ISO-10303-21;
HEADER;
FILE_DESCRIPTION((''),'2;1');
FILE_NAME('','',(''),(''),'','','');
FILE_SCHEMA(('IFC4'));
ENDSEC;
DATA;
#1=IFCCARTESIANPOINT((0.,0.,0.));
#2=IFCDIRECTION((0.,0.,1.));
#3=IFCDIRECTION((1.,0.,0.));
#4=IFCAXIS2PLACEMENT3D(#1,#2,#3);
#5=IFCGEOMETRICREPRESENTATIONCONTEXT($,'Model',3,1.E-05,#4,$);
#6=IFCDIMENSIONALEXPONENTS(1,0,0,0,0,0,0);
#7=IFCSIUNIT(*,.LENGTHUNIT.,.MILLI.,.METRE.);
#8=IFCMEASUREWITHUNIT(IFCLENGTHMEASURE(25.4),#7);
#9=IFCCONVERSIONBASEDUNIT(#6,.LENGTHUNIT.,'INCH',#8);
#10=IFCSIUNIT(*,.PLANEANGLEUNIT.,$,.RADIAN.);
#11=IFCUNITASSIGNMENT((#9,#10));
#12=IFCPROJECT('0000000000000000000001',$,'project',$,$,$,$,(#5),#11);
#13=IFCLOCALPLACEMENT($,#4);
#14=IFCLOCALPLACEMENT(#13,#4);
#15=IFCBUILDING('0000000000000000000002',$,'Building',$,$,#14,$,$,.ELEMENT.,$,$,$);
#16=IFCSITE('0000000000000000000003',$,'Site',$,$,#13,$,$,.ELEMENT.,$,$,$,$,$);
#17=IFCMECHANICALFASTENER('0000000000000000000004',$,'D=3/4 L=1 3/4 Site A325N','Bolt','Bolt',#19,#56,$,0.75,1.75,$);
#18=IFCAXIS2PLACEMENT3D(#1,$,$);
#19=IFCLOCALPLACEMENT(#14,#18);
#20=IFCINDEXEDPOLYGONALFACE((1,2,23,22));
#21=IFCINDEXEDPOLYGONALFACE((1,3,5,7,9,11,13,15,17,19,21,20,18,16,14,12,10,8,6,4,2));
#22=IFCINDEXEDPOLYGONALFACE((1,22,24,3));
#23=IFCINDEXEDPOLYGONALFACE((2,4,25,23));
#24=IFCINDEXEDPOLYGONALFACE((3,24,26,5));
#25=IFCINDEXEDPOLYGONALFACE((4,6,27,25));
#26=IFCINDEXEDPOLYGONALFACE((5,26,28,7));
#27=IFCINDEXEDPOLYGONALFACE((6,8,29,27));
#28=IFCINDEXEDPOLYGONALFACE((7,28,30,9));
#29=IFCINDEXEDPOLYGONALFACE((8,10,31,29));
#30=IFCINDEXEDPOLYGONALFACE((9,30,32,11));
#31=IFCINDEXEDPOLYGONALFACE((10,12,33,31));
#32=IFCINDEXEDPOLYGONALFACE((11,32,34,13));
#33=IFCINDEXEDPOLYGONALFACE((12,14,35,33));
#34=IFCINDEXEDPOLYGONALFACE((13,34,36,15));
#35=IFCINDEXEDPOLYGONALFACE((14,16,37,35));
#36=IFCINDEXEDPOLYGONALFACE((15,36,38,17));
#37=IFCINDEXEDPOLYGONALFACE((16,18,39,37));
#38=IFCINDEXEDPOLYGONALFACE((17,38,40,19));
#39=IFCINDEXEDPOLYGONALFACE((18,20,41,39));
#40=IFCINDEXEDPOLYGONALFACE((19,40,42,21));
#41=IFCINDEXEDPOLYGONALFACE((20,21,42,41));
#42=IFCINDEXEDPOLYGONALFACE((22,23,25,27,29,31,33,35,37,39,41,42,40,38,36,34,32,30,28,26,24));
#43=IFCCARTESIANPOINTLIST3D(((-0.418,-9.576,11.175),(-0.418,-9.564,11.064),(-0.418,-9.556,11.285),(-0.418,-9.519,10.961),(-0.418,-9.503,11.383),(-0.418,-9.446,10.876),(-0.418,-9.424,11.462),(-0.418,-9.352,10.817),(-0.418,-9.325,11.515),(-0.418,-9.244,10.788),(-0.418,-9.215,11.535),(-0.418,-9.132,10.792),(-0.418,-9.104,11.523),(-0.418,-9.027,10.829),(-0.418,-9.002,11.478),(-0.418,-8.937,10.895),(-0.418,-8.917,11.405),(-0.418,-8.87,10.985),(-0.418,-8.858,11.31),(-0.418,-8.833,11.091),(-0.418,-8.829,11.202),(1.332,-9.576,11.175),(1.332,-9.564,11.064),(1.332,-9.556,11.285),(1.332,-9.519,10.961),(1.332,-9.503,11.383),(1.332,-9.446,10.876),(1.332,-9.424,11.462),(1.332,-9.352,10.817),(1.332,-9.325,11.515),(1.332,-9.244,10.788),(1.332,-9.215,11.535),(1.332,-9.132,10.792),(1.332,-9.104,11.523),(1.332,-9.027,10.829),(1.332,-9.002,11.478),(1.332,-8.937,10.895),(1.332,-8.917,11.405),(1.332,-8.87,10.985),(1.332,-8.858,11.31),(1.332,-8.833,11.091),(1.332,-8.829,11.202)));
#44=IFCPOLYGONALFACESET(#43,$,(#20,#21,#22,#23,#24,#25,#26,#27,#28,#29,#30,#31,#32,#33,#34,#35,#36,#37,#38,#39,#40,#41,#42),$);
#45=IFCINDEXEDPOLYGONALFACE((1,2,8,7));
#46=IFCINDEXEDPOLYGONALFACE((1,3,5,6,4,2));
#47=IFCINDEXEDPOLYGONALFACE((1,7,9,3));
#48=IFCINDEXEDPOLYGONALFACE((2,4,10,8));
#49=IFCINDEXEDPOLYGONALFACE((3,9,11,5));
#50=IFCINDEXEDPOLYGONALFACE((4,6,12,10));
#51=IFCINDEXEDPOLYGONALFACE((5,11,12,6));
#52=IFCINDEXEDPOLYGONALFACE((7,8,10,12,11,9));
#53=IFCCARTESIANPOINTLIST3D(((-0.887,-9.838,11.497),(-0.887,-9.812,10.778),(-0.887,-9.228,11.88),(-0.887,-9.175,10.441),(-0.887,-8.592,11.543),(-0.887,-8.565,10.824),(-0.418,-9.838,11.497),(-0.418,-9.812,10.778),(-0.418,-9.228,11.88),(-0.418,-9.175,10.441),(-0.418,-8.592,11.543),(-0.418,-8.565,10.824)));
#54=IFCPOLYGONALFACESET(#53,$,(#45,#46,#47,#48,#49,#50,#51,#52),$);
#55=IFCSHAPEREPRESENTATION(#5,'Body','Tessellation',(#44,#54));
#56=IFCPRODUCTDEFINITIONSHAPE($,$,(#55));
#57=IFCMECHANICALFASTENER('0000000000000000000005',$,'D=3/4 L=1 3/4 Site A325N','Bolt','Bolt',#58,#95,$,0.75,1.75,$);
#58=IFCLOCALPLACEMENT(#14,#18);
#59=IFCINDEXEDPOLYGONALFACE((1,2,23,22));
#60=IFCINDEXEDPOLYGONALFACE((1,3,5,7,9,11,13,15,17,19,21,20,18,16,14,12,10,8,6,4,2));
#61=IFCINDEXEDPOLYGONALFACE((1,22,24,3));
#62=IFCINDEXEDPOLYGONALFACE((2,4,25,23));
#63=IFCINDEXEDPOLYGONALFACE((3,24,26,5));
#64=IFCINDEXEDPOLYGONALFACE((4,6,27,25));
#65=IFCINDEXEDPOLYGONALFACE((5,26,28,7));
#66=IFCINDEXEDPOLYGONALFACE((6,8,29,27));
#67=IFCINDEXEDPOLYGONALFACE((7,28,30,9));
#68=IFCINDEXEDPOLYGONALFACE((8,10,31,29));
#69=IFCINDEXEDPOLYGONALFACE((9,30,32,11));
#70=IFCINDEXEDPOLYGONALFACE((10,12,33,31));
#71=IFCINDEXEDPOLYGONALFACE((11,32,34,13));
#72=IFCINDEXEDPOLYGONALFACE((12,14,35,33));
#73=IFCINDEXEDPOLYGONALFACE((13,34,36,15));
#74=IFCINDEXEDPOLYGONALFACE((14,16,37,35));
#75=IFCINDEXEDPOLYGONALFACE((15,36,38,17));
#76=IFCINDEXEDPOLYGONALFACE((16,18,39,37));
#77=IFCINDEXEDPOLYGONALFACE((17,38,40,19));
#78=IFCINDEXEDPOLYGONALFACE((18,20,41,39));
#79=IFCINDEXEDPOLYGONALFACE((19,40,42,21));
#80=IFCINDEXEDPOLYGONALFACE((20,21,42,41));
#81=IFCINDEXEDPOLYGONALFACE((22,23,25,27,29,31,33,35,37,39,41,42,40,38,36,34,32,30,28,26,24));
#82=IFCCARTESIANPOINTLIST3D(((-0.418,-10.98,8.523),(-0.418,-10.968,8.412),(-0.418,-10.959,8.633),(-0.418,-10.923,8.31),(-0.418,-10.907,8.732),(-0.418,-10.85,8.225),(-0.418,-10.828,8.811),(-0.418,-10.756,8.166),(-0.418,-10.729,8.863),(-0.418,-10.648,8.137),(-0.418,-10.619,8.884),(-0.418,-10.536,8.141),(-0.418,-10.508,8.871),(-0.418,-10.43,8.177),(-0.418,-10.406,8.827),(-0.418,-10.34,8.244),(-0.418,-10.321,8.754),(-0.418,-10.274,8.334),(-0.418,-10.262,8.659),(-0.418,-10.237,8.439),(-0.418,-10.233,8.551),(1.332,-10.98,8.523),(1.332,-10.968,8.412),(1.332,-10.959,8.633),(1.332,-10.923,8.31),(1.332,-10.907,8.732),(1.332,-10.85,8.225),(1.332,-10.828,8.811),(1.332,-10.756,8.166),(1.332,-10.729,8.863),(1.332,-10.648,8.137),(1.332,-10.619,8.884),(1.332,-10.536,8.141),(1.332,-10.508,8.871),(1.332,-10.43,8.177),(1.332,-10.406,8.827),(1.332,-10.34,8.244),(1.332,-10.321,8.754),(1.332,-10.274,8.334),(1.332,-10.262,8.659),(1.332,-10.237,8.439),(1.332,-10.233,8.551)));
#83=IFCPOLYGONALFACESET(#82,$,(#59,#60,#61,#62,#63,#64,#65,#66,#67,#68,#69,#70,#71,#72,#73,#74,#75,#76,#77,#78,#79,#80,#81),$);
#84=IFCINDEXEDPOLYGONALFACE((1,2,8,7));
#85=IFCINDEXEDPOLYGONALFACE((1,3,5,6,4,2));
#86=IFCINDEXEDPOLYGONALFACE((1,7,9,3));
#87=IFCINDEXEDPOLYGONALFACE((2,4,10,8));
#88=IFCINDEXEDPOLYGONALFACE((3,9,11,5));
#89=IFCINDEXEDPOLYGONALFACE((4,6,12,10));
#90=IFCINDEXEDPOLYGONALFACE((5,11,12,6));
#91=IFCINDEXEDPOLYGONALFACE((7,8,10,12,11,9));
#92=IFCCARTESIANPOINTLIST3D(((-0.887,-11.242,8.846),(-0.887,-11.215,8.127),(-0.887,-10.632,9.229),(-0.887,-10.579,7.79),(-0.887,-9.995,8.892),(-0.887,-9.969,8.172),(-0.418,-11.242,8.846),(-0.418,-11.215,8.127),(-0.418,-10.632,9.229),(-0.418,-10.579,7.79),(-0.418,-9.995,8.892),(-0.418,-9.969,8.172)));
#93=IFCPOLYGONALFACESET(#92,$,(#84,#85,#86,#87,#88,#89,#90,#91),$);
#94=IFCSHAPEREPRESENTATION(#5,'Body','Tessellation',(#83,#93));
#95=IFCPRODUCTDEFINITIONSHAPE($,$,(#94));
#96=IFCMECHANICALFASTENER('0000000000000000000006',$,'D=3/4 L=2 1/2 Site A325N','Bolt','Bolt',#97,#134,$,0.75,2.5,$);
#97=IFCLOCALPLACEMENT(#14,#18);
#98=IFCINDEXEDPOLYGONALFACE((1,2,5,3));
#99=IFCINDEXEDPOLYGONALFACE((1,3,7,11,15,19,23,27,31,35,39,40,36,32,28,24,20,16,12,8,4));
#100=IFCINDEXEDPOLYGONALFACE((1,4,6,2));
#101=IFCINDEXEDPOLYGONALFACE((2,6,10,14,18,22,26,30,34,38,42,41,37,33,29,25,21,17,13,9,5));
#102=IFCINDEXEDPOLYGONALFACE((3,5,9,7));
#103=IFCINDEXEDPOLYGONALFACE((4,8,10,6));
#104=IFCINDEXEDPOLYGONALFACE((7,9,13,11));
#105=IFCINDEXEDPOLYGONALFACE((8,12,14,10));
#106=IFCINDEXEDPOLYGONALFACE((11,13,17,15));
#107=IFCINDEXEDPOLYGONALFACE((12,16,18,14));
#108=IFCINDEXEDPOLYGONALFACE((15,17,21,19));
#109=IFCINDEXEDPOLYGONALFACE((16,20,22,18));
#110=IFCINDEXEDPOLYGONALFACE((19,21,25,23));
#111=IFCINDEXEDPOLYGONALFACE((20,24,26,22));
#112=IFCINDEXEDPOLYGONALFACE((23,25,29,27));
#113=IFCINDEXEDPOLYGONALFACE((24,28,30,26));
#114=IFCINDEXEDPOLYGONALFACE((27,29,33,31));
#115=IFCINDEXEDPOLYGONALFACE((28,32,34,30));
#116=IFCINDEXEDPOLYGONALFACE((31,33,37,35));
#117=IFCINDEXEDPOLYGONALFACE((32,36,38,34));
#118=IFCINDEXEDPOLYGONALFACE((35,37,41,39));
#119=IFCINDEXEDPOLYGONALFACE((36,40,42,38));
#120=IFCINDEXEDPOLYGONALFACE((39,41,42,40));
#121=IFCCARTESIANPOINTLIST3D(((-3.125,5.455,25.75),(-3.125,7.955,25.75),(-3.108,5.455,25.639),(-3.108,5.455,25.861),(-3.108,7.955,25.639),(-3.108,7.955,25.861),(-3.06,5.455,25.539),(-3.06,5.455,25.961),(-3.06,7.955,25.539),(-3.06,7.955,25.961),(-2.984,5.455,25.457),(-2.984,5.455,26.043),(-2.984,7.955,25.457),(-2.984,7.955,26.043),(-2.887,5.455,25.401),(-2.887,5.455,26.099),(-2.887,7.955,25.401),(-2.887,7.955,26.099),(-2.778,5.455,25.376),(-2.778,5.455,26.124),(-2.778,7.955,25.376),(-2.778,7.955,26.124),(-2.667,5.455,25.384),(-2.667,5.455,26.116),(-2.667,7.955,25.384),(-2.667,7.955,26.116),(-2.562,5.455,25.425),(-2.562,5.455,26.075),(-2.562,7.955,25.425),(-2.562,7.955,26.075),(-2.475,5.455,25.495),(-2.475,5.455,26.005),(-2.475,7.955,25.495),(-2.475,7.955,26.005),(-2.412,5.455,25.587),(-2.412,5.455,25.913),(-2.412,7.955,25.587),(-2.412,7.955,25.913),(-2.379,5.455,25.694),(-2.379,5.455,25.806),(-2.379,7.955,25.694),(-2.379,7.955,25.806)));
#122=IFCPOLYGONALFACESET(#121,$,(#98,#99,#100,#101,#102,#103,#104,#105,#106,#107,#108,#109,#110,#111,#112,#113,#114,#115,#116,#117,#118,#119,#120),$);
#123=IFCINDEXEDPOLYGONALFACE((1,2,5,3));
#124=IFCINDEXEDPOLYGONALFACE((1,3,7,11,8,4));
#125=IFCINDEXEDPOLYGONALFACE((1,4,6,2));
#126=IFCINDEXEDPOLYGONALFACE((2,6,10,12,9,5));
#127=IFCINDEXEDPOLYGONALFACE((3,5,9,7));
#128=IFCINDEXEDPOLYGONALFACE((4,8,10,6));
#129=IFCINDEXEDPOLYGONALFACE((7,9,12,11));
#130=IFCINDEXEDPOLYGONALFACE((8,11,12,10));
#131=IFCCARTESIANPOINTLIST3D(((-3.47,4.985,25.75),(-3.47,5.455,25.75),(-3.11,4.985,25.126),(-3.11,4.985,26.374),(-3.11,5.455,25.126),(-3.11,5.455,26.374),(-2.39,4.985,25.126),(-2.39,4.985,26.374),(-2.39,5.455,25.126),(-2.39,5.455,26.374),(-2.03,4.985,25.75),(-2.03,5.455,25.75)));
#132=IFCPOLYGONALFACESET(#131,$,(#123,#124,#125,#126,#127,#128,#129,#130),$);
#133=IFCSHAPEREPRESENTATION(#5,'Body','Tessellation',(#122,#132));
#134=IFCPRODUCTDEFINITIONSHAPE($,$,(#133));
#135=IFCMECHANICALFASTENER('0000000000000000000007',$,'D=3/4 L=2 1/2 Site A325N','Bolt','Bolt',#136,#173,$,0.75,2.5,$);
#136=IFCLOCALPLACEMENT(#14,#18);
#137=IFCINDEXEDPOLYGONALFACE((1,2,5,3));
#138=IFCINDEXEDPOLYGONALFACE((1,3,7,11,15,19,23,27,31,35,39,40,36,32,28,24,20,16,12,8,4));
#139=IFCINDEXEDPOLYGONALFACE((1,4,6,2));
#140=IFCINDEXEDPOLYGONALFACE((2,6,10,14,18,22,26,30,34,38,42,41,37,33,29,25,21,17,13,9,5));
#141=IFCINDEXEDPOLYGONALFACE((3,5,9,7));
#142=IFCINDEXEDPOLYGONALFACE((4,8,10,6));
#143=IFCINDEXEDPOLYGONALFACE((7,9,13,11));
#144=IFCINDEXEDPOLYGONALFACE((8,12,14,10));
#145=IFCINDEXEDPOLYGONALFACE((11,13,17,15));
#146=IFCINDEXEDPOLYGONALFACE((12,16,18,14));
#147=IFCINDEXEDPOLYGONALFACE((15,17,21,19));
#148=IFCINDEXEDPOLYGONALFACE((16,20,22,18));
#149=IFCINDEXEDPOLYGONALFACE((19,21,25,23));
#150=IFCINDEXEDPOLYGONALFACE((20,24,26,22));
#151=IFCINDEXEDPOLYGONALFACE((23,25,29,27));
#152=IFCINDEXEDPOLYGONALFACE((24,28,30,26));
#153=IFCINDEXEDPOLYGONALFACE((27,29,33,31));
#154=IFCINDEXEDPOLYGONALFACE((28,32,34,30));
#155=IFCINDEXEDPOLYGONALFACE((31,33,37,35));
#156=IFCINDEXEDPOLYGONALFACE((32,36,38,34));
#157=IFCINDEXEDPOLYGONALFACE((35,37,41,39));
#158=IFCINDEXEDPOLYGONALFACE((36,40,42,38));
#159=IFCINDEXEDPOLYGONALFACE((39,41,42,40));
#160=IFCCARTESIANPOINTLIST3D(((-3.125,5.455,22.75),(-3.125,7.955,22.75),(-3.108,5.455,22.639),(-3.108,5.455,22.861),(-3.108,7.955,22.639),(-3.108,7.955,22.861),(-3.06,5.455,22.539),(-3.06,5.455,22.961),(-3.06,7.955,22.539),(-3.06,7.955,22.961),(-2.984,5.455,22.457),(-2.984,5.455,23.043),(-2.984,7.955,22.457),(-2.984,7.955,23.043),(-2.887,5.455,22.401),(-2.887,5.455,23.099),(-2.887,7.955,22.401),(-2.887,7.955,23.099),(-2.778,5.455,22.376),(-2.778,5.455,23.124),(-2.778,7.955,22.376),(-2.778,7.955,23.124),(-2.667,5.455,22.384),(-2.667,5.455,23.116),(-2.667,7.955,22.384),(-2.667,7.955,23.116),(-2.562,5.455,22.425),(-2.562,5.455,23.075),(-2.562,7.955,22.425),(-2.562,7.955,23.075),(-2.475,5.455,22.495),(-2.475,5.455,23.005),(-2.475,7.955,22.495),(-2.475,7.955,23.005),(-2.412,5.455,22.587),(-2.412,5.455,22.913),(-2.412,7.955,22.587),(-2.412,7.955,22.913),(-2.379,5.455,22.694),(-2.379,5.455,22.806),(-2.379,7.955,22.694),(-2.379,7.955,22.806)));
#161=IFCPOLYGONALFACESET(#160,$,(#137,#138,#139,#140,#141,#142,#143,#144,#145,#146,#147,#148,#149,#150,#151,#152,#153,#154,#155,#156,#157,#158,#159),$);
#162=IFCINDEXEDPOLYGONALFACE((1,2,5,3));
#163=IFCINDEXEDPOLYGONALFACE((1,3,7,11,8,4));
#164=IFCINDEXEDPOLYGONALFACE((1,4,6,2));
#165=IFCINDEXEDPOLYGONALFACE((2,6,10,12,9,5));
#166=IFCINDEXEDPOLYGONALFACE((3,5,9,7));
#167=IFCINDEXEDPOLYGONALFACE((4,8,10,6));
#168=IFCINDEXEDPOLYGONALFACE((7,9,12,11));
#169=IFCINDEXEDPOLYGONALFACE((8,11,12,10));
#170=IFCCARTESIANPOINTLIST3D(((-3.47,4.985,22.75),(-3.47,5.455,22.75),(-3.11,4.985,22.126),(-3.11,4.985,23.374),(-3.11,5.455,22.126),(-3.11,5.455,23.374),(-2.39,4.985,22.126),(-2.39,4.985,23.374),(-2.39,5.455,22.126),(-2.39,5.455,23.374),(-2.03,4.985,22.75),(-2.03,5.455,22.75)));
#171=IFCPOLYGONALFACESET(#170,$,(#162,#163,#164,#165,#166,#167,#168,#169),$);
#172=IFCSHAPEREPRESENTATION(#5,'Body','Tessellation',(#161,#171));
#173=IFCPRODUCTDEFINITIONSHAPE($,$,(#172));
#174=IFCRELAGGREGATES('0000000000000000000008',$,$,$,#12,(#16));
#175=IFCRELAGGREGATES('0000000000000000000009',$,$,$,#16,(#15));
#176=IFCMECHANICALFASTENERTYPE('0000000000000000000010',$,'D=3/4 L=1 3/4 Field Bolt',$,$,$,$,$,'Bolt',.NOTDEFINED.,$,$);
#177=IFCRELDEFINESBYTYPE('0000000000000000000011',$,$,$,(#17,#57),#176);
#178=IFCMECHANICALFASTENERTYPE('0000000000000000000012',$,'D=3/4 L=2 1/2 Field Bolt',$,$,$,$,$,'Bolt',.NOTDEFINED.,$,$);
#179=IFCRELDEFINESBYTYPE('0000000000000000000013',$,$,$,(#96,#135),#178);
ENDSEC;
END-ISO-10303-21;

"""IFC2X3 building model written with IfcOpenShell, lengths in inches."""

from ifc_helpers import new_model, entity, si_unit, converted_unit, frame, origin_with_axes, origin_2d_with_axis, place, context, project, spatial, polyline, circle, outline, extrude, source, transform, mapped, type_object, type_shapes, element, save


model = new_model("IFC2X3")

# Units and contexts
model_context = context("Model", 3, precision=1e-05, world=origin_with_axes())
ifc_project = project(units=[converted_unit("LENGTHUNIT", "INCH", entity("IfcLengthMeasure", 25.4), si_unit("LENGTHUNIT", "METRE", prefix="MILLI"), dimensions=[1, 0, 0, 0, 0, 0, 0]), si_unit("PLANEANGLEUNIT", "RADIAN")], contexts=[model_context])

# Site, building
site_placement = place(None, origin_with_axes())
site = spatial("IfcSite", under=ifc_project, at=site_placement, Name="Site", CompositionType="ELEMENT")
building_placement = place(site_placement, origin_with_axes())
building = spatial("IfcBuilding", under=site, at=building_placement, Name="Building", CompositionType="ELEMENT")

# Mechanical fasteners
mechanical_fastener_type_1 = type_object("IfcMechanicalFastenerType", Name="D=3/4 L=1 3/4 Field Bolt", ElementType="Bolt")
shared_shape_1 = source(origin_with_axes(), model_context, "Body", "SweptSolid", [
    extrude(circle(Radius=0.375, at=origin_2d_with_axis()), frame((0.0, 0.0, 0.0), z_axis=(1.0, 0.0, 0.0), x_axis=(0.0, 1.0, 0.0)), (0.0, 0.0, 1.0), 1.75),
    extrude(outline(polyline([(-0.72, 0.0), (-0.36, 0.624), (0.36, 0.624), (0.72, 0.0), (0.36, -0.624), (-0.36, -0.624), (-0.72, 0.0)])), frame((0.0, 0.0, 0.0), z_axis=(1.0, 0.0, 0.0), x_axis=(0.0, 1.0, 0.0)), (0.0, 0.0, -1.0), 0.47),
])
type_shapes(mechanical_fastener_type_1, [shared_shape_1])
placement_1 = place(building_placement, frame((-0.303, -6.355, 7.978), z_axis=(0.0, 0.470284, 0.882515), x_axis=(0.0, -0.882515, 0.470284)))
placement_2 = place(placement_1, frame((4.009, -0.115, 1.47), z_axis=(0.002713, 0.0, 0.999996), x_axis=(0.0, 1.0, 0.0)))
for number, where, z_axis, x_axis, name in (
    (1, (0.0, 0.0, 0.0), (0.0, 0.0, 1.0), (1.0, 0.0, 0.0), "D=3/4 L=1 3/4 Site A325N"),
    (2, (0.0, 0.0, -3.0), (0.0, 0.0, 1.0), (1.0, 0.0, 0.0), "D=3/4 L=1 3/4 Site A325N"),
):
    element("IfcMechanicalFastener", number, at=place(placement_2, frame(where, z_axis=z_axis, x_axis=x_axis)), type_object=mechanical_fastener_type_1, Name=name, Description="Bolt", ObjectType="Bolt", NominalDiameter=0.75, NominalLength=1.75, context=model_context, shape_type="MappedRepresentation", body=[
        mapped(shared_shape_1, transform((0.0, 0.0, 0.0), scale=1.0)),
    ])
mechanical_fastener_type_2 = type_object("IfcMechanicalFastenerType", Name="D=3/4 L=2 1/2 Field Bolt", ElementType="Bolt")
shared_shape_2 = source(origin_with_axes(), model_context, "Body", "SweptSolid", [
    extrude(circle(Radius=0.375, at=origin_2d_with_axis()), frame((0.0, 0.0, 0.0), z_axis=(1.0, 0.0, 0.0), x_axis=(0.0, 1.0, 0.0)), (0.0, 0.0, 1.0), 2.5),
    extrude(outline(polyline([(-0.72, 0.0), (-0.36, 0.624), (0.36, 0.624), (0.72, 0.0), (0.36, -0.624), (-0.36, -0.624), (-0.72, 0.0)])), frame((0.0, 0.0, 0.0), z_axis=(1.0, 0.0, 0.0), x_axis=(0.0, 1.0, 0.0)), (0.0, 0.0, -1.0), 0.47),
])
type_shapes(mechanical_fastener_type_2, [shared_shape_2])
placement_3 = place(building_placement, frame((0.0, 0.0, 21.0), z_axis=(0.0, -1.0, 0.0), x_axis=(0.0, 0.0, 1.0)))
placement_4 = place(placement_3, frame((4.75, -2.75, -5.455), z_axis=(1.0, 0.0, 0.0), x_axis=(0.0, 0.0, -1.0)))
for number, where, z_axis, x_axis, name in (
    (3, (0.0, 5.5, 0.0), (0.0, 0.0, 1.0), (1.0, 0.0, 0.0), "D=3/4 L=2 1/2 Site A325N"),
    (4, (0.0, 5.5, -3.0), (0.0, 0.0, 1.0), (1.0, 0.0, 0.0), "D=3/4 L=2 1/2 Site A325N"),
):
    element("IfcMechanicalFastener", number, at=place(placement_4, frame(where, z_axis=z_axis, x_axis=x_axis)), type_object=mechanical_fastener_type_2, Name=name, Description="Bolt", ObjectType="Bolt", NominalDiameter=0.75, NominalLength=2.5, context=model_context, shape_type="MappedRepresentation", body=[
        mapped(shared_shape_2, transform((0.0, 0.0, 0.0), scale=1.0)),
    ])

save(model, "model.ifc")
